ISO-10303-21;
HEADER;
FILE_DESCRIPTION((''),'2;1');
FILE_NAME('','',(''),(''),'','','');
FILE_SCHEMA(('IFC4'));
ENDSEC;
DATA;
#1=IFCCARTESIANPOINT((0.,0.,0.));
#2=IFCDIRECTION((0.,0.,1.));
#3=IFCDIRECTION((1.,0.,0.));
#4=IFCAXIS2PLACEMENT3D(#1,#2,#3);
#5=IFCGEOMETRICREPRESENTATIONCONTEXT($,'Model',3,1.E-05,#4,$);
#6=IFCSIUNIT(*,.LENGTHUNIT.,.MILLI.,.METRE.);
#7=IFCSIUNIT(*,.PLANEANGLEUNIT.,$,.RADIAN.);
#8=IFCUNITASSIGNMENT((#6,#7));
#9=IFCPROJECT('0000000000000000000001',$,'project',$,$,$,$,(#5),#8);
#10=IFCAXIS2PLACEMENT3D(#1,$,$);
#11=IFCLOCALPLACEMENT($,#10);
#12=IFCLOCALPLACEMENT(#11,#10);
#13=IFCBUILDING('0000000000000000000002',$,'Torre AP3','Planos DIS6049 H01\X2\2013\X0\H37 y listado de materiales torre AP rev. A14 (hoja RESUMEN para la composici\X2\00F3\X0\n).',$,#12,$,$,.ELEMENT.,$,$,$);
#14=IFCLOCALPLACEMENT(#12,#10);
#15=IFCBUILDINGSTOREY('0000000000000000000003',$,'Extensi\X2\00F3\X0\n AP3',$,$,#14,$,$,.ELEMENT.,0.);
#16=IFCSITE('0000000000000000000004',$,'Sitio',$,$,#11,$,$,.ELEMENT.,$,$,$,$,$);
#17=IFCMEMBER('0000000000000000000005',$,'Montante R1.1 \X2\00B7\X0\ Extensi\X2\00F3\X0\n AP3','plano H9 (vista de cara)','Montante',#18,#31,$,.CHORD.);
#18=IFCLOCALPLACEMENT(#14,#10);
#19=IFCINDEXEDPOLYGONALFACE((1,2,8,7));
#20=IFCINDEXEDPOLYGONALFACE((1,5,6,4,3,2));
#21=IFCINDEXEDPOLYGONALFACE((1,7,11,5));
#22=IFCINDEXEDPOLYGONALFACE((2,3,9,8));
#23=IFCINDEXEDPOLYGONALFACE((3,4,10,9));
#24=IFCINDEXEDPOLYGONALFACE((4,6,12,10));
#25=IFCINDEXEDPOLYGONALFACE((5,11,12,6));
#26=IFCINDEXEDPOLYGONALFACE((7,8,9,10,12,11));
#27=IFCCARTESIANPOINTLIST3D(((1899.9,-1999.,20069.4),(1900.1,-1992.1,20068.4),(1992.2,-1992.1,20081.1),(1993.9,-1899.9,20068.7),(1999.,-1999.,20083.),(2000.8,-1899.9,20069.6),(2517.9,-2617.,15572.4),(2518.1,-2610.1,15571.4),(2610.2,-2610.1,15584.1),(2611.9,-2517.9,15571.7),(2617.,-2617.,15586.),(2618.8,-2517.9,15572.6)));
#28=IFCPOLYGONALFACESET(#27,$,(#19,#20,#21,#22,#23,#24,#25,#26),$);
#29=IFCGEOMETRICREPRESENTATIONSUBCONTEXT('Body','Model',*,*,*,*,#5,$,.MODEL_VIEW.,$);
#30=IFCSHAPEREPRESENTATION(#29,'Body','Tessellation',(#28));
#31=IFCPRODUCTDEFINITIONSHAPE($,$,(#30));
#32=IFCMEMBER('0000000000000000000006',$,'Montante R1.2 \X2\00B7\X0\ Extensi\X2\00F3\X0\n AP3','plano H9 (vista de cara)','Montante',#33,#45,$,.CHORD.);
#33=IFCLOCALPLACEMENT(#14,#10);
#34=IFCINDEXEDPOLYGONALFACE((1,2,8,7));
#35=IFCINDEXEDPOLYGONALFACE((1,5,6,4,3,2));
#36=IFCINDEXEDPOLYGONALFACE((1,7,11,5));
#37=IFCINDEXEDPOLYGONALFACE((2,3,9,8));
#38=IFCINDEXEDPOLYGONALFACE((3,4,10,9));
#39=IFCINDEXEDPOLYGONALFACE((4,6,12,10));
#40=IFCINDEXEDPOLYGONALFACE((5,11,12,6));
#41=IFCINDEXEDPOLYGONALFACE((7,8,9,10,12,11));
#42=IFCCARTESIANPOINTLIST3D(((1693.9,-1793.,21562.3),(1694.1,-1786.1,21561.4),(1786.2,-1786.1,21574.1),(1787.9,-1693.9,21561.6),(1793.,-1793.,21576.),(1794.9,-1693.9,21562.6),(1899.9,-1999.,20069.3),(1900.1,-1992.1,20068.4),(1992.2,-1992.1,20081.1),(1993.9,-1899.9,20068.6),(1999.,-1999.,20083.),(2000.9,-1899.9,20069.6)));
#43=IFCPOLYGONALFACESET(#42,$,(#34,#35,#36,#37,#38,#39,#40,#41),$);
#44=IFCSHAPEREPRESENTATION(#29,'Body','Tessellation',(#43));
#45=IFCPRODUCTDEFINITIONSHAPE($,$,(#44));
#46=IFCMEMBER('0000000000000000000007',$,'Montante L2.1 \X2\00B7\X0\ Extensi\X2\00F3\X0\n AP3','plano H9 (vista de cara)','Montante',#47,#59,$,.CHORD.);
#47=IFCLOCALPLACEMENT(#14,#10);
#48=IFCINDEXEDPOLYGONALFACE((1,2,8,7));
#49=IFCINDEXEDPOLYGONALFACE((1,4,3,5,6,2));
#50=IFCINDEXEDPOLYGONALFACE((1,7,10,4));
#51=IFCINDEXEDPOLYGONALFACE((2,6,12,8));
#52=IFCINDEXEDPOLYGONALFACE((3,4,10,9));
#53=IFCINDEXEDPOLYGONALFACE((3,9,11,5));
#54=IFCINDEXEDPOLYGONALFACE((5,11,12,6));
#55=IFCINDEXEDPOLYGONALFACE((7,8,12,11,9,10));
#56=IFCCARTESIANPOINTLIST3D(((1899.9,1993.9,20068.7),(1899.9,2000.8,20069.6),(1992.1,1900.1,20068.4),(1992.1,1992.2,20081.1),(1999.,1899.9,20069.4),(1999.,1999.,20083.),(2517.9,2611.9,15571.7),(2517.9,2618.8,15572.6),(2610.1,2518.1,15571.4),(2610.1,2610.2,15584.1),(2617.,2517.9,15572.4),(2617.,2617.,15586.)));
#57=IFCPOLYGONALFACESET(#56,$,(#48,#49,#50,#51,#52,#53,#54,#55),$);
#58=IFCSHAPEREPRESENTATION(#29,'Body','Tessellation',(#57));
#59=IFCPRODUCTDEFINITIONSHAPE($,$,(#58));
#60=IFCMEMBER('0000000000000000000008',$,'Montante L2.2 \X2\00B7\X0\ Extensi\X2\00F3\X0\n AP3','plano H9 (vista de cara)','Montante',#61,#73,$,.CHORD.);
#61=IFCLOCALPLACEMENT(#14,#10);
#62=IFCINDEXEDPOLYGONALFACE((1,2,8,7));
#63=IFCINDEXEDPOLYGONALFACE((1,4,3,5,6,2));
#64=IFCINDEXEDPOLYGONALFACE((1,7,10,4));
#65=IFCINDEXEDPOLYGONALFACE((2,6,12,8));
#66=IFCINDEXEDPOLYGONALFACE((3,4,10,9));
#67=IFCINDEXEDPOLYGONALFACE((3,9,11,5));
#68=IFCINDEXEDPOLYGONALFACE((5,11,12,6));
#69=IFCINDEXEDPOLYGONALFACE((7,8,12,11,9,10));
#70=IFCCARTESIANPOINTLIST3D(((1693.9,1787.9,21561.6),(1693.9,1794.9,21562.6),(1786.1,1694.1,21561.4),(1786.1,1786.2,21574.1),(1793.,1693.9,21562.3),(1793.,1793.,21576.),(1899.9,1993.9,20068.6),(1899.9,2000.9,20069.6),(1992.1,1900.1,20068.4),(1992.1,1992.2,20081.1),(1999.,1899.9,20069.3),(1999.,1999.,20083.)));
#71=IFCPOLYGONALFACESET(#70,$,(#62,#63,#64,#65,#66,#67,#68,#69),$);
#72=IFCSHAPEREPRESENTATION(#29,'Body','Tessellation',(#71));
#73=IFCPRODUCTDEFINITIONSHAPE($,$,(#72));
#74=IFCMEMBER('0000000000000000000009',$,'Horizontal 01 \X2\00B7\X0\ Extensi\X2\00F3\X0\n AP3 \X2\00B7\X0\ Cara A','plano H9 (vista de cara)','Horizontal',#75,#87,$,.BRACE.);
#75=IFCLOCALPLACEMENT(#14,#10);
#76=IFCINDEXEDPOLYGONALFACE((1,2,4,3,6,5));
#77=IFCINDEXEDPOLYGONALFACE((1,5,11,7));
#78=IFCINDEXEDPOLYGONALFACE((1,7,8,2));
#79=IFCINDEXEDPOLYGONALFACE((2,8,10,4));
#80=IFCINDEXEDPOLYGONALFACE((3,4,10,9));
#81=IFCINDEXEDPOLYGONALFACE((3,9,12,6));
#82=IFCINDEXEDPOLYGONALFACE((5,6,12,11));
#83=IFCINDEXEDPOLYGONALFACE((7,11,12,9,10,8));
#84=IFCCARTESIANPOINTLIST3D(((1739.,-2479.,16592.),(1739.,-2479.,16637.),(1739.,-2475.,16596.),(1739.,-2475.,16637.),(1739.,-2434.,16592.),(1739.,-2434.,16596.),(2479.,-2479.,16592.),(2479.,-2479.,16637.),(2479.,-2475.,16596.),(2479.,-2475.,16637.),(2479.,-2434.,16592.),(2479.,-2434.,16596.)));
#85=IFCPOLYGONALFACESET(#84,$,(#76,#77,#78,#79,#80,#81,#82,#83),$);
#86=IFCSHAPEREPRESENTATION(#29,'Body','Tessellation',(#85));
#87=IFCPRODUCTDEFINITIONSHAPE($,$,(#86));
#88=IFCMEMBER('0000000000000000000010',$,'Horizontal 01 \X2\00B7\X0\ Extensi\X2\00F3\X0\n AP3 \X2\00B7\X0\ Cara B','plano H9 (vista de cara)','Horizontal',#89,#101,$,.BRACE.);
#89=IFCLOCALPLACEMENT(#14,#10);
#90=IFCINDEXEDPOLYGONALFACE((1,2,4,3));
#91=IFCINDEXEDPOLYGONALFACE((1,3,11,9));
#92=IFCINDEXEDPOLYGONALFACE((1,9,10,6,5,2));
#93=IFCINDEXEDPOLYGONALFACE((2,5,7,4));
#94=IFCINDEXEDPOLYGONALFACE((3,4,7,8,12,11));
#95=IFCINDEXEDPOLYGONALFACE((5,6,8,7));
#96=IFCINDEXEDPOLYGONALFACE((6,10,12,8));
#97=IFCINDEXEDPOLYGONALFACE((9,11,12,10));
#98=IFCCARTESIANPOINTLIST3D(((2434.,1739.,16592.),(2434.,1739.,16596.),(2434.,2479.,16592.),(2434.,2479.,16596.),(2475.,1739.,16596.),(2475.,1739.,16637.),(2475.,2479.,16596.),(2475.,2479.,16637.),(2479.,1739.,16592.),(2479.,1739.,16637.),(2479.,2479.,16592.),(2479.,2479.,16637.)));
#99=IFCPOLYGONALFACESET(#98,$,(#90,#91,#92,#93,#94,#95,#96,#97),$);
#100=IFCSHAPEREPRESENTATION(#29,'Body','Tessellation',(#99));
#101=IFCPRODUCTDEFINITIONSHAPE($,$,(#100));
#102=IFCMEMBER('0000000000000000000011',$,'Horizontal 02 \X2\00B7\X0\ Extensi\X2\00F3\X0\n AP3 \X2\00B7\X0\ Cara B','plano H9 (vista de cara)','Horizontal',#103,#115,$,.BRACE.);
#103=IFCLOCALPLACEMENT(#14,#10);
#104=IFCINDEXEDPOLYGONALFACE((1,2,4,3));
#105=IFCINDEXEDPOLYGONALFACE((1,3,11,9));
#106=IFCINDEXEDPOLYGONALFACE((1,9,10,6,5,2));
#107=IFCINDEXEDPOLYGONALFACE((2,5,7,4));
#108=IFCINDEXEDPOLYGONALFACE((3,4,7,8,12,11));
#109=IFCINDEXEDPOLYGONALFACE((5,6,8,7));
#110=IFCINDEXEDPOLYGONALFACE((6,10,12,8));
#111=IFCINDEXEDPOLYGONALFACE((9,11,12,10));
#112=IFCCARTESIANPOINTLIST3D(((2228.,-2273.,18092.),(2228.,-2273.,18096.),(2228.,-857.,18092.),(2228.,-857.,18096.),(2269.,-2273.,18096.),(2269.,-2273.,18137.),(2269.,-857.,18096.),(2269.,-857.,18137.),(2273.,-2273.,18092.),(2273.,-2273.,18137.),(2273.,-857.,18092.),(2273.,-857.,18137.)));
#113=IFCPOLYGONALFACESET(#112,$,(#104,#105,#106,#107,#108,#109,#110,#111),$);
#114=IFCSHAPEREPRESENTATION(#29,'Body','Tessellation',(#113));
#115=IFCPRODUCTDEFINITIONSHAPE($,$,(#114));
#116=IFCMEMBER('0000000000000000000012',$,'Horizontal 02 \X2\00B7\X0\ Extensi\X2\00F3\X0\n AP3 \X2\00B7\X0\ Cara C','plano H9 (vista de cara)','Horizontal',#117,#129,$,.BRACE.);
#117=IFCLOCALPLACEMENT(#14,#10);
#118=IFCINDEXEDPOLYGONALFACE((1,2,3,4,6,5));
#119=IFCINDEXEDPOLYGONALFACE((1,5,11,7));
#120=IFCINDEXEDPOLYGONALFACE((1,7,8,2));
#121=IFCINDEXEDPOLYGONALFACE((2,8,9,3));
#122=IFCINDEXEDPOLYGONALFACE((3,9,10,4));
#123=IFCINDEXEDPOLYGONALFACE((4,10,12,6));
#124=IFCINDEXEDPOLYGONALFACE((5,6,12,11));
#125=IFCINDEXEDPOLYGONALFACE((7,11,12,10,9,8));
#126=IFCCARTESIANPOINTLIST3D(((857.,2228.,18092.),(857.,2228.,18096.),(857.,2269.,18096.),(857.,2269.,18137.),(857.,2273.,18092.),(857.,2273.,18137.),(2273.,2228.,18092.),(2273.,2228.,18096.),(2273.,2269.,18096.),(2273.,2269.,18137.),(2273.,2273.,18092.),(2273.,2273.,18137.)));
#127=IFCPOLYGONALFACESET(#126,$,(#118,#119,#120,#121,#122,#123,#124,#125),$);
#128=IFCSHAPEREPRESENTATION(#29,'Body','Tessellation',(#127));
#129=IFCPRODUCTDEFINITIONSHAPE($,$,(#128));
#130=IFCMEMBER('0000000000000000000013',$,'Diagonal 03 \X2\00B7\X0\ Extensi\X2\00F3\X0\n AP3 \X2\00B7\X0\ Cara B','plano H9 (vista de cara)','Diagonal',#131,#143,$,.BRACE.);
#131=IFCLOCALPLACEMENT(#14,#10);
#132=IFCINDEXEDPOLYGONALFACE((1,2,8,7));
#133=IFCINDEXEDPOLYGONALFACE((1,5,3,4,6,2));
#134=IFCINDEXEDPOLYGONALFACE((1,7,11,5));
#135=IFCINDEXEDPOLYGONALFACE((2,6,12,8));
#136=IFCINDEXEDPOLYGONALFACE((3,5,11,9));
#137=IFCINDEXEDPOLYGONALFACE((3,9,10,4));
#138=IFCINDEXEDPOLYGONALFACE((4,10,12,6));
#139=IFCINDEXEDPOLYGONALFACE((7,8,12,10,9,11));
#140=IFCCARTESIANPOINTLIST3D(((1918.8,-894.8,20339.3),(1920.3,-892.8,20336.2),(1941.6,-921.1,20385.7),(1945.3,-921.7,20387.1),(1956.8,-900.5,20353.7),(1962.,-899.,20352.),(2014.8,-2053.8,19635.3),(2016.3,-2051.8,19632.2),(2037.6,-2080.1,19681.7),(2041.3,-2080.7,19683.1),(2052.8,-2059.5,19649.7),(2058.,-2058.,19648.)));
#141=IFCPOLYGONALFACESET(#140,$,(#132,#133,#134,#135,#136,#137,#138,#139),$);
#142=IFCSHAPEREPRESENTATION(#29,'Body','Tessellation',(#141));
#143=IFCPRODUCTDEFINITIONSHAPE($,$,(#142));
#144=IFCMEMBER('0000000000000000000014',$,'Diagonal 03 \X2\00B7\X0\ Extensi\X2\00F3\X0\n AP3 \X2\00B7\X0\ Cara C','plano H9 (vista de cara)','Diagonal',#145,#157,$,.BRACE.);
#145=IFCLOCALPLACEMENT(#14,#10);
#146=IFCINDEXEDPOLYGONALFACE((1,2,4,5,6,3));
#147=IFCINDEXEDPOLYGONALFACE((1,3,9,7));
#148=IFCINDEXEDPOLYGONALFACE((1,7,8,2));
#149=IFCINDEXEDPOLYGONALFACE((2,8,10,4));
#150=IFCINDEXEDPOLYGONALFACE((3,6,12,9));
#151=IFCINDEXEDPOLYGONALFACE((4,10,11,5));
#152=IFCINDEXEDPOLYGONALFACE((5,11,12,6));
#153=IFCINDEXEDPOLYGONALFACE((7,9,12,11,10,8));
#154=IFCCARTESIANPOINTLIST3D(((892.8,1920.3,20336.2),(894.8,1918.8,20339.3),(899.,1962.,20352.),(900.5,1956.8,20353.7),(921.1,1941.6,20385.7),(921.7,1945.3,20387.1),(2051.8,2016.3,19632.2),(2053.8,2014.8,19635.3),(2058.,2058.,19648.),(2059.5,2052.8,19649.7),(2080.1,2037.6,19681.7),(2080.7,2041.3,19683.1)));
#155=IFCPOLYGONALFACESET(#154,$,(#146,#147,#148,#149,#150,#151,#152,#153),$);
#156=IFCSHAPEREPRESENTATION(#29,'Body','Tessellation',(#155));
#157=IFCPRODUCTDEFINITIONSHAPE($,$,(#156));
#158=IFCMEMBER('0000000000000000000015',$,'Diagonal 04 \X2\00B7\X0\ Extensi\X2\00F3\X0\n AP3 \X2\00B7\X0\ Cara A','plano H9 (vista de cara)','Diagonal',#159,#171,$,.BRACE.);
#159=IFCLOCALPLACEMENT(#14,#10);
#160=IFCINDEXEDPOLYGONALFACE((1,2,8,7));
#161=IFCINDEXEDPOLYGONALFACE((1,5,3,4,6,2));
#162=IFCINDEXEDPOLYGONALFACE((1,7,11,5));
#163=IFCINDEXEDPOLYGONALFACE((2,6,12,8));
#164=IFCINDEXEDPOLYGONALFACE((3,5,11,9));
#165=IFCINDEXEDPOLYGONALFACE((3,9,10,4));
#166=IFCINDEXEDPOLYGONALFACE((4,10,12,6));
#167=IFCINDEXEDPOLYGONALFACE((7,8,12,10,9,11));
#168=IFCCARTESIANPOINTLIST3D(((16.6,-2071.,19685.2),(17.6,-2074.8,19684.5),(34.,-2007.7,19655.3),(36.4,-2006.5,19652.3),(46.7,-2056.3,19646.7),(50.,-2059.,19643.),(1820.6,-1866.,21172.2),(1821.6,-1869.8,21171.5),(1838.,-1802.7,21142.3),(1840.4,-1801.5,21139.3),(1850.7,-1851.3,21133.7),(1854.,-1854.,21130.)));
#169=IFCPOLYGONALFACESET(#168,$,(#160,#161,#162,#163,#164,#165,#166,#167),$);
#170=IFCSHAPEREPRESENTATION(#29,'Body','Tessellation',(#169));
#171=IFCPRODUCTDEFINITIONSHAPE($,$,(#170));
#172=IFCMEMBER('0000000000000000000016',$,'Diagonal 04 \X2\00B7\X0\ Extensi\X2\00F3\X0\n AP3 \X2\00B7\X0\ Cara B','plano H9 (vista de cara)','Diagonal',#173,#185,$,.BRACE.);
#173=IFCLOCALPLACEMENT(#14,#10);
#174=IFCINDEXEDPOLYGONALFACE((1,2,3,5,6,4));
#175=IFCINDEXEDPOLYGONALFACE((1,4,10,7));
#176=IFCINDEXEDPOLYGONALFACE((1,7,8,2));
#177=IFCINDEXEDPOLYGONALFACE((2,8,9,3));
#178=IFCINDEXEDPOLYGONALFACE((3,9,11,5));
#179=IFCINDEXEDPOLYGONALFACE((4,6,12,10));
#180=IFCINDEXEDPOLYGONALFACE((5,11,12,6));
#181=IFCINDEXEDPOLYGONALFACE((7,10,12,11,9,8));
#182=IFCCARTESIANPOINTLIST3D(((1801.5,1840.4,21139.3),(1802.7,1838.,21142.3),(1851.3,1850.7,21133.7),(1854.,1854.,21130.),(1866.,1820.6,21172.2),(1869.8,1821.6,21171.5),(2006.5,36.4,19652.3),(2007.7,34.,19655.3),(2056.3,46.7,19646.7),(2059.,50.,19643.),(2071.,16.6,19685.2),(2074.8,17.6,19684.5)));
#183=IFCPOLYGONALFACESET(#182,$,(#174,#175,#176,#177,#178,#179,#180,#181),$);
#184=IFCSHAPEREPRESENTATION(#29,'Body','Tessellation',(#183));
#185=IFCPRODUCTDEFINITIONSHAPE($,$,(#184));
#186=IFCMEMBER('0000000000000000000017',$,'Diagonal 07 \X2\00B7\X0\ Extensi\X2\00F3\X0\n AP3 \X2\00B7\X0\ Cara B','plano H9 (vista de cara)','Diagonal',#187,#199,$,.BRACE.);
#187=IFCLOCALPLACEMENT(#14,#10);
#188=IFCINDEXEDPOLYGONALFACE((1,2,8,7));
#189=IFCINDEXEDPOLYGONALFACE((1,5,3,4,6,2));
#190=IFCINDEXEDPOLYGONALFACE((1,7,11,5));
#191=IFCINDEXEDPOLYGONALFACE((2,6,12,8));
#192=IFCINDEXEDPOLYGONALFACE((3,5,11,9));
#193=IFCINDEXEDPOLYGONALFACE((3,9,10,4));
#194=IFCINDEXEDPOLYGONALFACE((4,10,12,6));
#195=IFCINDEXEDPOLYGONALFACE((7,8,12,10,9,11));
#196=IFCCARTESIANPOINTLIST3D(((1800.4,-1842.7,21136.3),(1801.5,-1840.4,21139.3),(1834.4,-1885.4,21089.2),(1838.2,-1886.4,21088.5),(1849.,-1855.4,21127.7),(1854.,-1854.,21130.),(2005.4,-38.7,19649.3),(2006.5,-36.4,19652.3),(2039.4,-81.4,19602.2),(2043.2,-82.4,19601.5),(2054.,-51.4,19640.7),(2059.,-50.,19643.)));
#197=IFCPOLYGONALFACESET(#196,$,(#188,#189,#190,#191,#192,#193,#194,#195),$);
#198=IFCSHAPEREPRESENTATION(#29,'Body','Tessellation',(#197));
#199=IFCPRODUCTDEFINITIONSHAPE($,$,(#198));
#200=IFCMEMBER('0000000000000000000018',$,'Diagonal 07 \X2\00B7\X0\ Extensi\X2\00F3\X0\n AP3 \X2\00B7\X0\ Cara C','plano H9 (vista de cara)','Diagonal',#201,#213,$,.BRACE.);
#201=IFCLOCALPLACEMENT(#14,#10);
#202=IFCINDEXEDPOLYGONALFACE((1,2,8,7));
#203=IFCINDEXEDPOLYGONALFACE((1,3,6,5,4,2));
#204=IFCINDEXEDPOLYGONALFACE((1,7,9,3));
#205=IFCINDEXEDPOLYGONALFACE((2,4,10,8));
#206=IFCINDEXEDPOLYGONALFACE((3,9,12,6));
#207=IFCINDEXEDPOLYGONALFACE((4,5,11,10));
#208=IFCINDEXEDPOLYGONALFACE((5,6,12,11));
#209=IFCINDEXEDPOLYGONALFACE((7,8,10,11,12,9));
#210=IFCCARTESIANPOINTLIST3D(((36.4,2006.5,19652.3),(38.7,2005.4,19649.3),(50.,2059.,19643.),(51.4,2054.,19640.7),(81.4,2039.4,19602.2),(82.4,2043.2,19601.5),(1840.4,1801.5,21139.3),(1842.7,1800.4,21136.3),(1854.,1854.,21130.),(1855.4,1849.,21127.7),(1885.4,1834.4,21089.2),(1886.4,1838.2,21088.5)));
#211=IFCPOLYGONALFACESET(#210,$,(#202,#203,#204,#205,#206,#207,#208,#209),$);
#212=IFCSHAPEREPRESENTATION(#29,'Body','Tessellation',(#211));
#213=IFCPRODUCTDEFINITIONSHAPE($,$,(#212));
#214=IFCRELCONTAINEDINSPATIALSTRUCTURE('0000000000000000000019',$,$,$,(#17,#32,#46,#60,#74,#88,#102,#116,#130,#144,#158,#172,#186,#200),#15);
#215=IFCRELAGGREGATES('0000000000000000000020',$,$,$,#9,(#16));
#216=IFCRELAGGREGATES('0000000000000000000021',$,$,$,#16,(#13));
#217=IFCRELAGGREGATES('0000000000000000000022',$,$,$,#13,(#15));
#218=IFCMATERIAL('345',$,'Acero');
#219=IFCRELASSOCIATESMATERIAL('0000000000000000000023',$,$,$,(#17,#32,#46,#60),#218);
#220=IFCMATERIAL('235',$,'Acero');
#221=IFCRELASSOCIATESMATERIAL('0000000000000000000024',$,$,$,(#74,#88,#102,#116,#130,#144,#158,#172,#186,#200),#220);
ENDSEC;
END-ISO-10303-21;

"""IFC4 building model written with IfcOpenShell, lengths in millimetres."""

from ifc_helpers import new_model, si_unit, frame, frame_2d, origin, origin_with_axes, place, context, subcontext, project, spatial, l_section, extrude, material, element, save


model = new_model("IFC4")

# Units and contexts
model_context = context("Model", 3, precision=1e-05, world=origin_with_axes())
body_context = subcontext(model_context, "Body", "Model", "MODEL_VIEW")
ifc_project = project(units=[si_unit("LENGTHUNIT", "METRE", prefix="MILLI"), si_unit("PLANEANGLEUNIT", "RADIAN")], contexts=[model_context])

# Site, building, storey
site_placement = place(None, origin())
site = spatial("IfcSite", under=ifc_project, at=site_placement, Name="Sitio", CompositionType="ELEMENT")
building_placement = place(site_placement, origin())
building = spatial("IfcBuilding", under=site, at=building_placement, Name="Torre AP3", Description="Planos DIS6049 H01–H37 y listado de materiales torre AP rev. A14 (hoja RESUMEN para la composición).", CompositionType="ELEMENT")
storey_placement = place(building_placement, origin())
storey = spatial("IfcBuildingStorey", under=building, at=storey_placement, Name="Extensión AP3", CompositionType="ELEMENT", Elevation=0.0)

# Members
ifc_material_1 = material(Name="345", Category="Acero")
member_1_placement = place(storey_placement, frame((2617.0, -2617.0, 15586.0), z_axis=(-0.134901, 0.134901, 0.981633), x_axis=(0.018366, 0.990859, -0.133645)))
element("IfcMember", 1, at=member_1_placement, inside=storey, material=ifc_material_1, Name="Montante R1.1 · Extensión AP3", Description="plano H9 (vista de cara)", ObjectType="Montante", PredefinedType="CHORD", context=body_context, shape_type="SweptSolid", body=[
    extrude(l_section(Depth=100.0, Width=100.0, Thickness=7.0, at=frame_2d((50.0, 50.0))), None, (0.0, 0.0, 1.0), 4581.1),
])
member_2_placement = place(storey_placement, frame((1999.0, -1999.0, 20083.0), z_axis=(-0.135423, 0.135423, 0.981489), x_axis=(0.01851, 0.990788, -0.134152)))
element("IfcMember", 2, at=member_2_placement, inside=storey, material=ifc_material_1, Name="Montante R1.2 · Extensión AP3", Description="plano H9 (vista de cara)", ObjectType="Montante", PredefinedType="CHORD", context=body_context, shape_type="SweptSolid", body=[
    extrude(l_section(Depth=100.0, Width=100.0, Thickness=7.0, at=frame_2d((50.0, 50.0))), None, (0.0, 0.0, 1.0), 1521.2),
])
member_3_placement = place(storey_placement, frame((2617.0, 2617.0, 15586.0), z_axis=(-0.134901, -0.134901, 0.981633), x_axis=(-0.990859, 0.018366, -0.133645)))
element("IfcMember", 3, at=member_3_placement, inside=storey, material=ifc_material_1, Name="Montante L2.1 · Extensión AP3", Description="plano H9 (vista de cara)", ObjectType="Montante", PredefinedType="CHORD", context=body_context, shape_type="SweptSolid", body=[
    extrude(l_section(Depth=100.0, Width=100.0, Thickness=7.0, at=frame_2d((50.0, 50.0))), None, (0.0, 0.0, 1.0), 4581.1),
])
member_4_placement = place(storey_placement, frame((1999.0, 1999.0, 20083.0), z_axis=(-0.135423, -0.135423, 0.981489), x_axis=(-0.990788, 0.01851, -0.134152)))
element("IfcMember", 4, at=member_4_placement, inside=storey, material=ifc_material_1, Name="Montante L2.2 · Extensión AP3", Description="plano H9 (vista de cara)", ObjectType="Montante", PredefinedType="CHORD", context=body_context, shape_type="SweptSolid", body=[
    extrude(l_section(Depth=100.0, Width=100.0, Thickness=7.0, at=frame_2d((50.0, 50.0))), None, (0.0, 0.0, 1.0), 1521.2),
])
ifc_material_2 = material(Name="235", Category="Acero")
for number, where, z_axis, x_axis, name in (
    (5, (1739.0, -2479.0, 16592.0), (1.0, 0.0, 0.0), (0.0, 1.0, 0.0), "Horizontal 01 · Extensión AP3 · Cara A"),
    (6, (2479.0, 1739.0, 16592.0), (0.0, 1.0, 0.0), (-1.0, 0.0, 0.0), "Horizontal 01 · Extensión AP3 · Cara B"),
):
    element("IfcMember", number, at=place(storey_placement, frame(where, z_axis=z_axis, x_axis=x_axis)), inside=storey, material=ifc_material_2, Name=name, Description="plano H9 (vista de cara)", ObjectType="Horizontal", PredefinedType="BRACE", context=body_context, shape_type="SweptSolid", body=[
        extrude(l_section(Depth=45.0, Width=45.0, Thickness=4.0, at=frame_2d((22.5, 22.5))), None, (0.0, 0.0, 1.0), 740.0),
    ])
for number, where, z_axis, x_axis, name in (
    (7, (2273.0, -2273.0, 18092.0), (0.0, 1.0, 0.0), (-1.0, 0.0, 0.0), "Horizontal 02 · Extensión AP3 · Cara B"),
    (8, (2273.0, 2273.0, 18092.0), (-1.0, 0.0, 0.0), (0.0, -1.0, 0.0), "Horizontal 02 · Extensión AP3 · Cara C"),
):
    element("IfcMember", number, at=place(storey_placement, frame(where, z_axis=z_axis, x_axis=x_axis)), inside=storey, material=ifc_material_2, Name=name, Description="plano H9 (vista de cara)", ObjectType="Horizontal", PredefinedType="BRACE", context=body_context, shape_type="SweptSolid", body=[
        extrude(l_section(Depth=45.0, Width=45.0, Thickness=4.0, at=frame_2d((22.5, 22.5))), None, (0.0, 0.0, 1.0), 1416.0),
    ])
for number, where, z_axis, x_axis, name in (
    (9, (2058.0, -2058.0, 19648.0), (-0.070617, 0.852549, 0.517855), (-0.925948, 0.137057, -0.351904), "Diagonal 03 · Extensión AP3 · Cara B"),
    (10, (2058.0, 2058.0, 19648.0), (-0.852549, -0.070617, 0.517855), (-0.137057, -0.925948, -0.351904), "Diagonal 03 · Extensión AP3 · Cara C"),
):
    element("IfcMember", number, at=place(storey_placement, frame(where, z_axis=z_axis, x_axis=x_axis)), inside=storey, material=ifc_material_2, Name=name, Description="plano H9 (vista de cara)", ObjectType="Diagonal", PredefinedType="BRACE", context=body_context, shape_type="SweptSolid", body=[
        extrude(l_section(Depth=45.0, Width=45.0, Thickness=4.0, at=frame_2d((22.5, 22.5))), None, (0.0, 0.0, 1.0), 1359.5),
    ])
for number, where, z_axis, x_axis, name in (
    (11, (50.0, -2059.0, 19643.0), (0.768697, 0.087352, 0.633621), (-0.247751, 0.953961, 0.169052), "Diagonal 04 · Extensión AP3 · Cara A"),
    (12, (2059.0, 50.0, 19643.0), (-0.087352, 0.768697, 0.633621), (-0.953961, -0.247751, 0.169052), "Diagonal 04 · Extensión AP3 · Cara B"),
):
    element("IfcMember", number, at=place(storey_placement, frame(where, z_axis=z_axis, x_axis=x_axis)), inside=storey, material=ifc_material_2, Name=name, Description="plano H9 (vista de cara)", ObjectType="Diagonal", PredefinedType="BRACE", context=body_context, shape_type="SweptSolid", body=[
        extrude(l_section(Depth=55.0, Width=55.0, Thickness=4.0, at=frame_2d((27.5, 27.5))), None, (0.0, 0.0, 1.0), 2346.8),
    ])
for number, where, z_axis, x_axis, name in (
    (13, (2059.0, -50.0, 19643.0), (-0.087352, -0.768697, 0.633621), (-0.953961, 0.247751, 0.169052), "Diagonal 07 · Extensión AP3 · Cara B"),
    (14, (50.0, 2059.0, 19643.0), (0.768697, -0.087352, 0.633621), (-0.247751, -0.953961, 0.169052), "Diagonal 07 · Extensión AP3 · Cara C"),
):
    element("IfcMember", number, at=place(storey_placement, frame(where, z_axis=z_axis, x_axis=x_axis)), inside=storey, material=ifc_material_2, Name=name, Description="plano H9 (vista de cara)", ObjectType="Diagonal", PredefinedType="BRACE", context=body_context, shape_type="SweptSolid", body=[
        extrude(l_section(Depth=55.0, Width=55.0, Thickness=4.0, at=frame_2d((27.5, 27.5))), None, (0.0, 0.0, 1.0), 2346.8),
    ])

save(model, "model.ifc")
